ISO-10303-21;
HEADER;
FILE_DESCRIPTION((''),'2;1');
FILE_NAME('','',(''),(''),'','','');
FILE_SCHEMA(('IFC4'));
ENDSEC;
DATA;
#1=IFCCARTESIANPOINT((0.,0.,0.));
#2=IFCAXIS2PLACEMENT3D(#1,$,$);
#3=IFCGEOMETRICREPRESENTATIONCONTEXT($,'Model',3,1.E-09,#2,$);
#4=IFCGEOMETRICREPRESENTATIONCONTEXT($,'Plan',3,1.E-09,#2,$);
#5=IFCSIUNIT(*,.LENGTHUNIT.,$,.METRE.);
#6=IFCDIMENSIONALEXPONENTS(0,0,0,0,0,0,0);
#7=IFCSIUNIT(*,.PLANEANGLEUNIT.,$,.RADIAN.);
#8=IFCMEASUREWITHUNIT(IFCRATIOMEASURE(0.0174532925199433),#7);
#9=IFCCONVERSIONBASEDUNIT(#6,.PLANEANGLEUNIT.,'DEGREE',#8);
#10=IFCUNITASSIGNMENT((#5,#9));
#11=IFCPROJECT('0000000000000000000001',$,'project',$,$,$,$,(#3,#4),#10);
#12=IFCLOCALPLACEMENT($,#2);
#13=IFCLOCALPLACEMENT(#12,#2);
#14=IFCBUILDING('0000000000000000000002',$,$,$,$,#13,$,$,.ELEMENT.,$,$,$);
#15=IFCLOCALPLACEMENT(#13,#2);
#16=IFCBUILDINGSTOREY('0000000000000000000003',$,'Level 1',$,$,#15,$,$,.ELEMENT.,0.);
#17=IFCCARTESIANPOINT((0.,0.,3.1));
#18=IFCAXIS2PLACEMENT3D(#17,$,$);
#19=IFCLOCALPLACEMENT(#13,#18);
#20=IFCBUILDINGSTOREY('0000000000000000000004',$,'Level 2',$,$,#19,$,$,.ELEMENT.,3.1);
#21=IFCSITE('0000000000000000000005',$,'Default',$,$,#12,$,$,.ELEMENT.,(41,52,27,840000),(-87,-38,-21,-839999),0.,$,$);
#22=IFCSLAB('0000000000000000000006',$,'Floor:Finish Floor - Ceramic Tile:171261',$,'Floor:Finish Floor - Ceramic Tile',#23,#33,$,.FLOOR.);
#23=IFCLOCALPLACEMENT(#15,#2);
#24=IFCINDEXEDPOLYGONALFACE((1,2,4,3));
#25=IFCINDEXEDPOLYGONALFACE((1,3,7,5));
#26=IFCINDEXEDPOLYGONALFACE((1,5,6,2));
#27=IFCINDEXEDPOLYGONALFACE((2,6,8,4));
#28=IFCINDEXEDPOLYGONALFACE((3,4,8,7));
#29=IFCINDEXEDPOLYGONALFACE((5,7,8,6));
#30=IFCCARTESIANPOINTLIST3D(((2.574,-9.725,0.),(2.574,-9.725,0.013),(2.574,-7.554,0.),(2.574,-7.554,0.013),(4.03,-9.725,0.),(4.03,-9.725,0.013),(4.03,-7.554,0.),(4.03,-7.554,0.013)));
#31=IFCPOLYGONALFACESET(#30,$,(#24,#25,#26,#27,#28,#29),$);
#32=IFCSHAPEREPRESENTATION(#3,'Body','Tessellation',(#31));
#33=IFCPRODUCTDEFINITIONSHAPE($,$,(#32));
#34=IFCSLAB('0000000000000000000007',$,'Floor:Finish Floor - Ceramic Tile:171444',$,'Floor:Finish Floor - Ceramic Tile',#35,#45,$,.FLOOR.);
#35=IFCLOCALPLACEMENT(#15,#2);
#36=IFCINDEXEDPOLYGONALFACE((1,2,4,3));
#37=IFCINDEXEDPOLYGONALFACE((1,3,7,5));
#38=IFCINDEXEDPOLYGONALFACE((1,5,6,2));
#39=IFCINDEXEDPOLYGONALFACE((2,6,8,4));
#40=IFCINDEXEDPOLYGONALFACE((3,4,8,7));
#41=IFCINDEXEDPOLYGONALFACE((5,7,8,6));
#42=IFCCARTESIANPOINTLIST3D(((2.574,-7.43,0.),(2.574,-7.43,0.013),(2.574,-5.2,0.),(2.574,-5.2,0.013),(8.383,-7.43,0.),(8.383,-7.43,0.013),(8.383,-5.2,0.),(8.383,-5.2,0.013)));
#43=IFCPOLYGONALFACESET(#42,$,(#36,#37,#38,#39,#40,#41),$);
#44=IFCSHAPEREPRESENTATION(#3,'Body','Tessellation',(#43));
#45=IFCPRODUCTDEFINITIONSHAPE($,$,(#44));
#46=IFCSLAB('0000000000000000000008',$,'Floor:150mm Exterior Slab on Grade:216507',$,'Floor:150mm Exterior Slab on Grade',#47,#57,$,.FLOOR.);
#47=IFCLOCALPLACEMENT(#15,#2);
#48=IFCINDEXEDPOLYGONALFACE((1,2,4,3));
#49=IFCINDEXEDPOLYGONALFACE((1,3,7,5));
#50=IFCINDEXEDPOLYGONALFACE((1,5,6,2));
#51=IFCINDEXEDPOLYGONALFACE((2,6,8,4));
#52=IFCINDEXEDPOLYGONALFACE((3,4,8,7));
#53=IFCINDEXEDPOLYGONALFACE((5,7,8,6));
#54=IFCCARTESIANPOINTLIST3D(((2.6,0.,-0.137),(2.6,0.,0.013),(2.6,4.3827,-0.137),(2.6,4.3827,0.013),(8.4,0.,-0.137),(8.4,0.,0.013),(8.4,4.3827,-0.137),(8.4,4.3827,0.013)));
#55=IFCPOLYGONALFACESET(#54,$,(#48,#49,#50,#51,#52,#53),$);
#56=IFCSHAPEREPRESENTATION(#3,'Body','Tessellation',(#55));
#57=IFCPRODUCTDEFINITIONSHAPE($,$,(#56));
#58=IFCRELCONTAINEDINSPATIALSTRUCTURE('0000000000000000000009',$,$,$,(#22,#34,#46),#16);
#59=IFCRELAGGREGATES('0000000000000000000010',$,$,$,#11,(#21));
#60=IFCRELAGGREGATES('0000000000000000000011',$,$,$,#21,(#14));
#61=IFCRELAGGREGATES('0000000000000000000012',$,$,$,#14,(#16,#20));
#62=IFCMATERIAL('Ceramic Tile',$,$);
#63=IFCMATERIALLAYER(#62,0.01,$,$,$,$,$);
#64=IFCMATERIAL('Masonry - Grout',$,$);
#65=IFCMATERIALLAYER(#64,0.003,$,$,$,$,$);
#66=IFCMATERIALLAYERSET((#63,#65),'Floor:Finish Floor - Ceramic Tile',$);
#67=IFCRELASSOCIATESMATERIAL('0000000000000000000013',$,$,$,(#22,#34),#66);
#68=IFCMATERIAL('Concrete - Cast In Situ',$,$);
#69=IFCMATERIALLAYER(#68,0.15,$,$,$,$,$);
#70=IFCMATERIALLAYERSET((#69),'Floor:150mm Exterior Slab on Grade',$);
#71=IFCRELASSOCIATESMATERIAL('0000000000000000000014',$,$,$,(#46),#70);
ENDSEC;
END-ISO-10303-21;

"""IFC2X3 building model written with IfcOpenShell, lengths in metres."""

from ifc_helpers import new_model, entity, si_unit, converted_unit, frame, frame_2d, origin, place, context, project, spatial, rectangle, extrude, material, layer, layer_set, layer_usage, element, save


model = new_model("IFC2X3")

# Units and contexts
model_context = context("Model", 3, precision=1e-09, world=origin())
plan_context = context("Plan", 3, precision=1e-09, world=origin())
ifc_project = project(units=[si_unit("LENGTHUNIT", "METRE"), converted_unit("PLANEANGLEUNIT", "DEGREE", entity("IfcRatioMeasure", 0.0174532925199433), si_unit("PLANEANGLEUNIT", "RADIAN"), dimensions=[0, 0, 0, 0, 0, 0, 0])], contexts=[model_context, plan_context])

# Site, building, storey
site_placement = place(None, origin())
site = spatial("IfcSite", under=ifc_project, at=site_placement, Name="Default", CompositionType="ELEMENT", RefLatitude=(41, 52, 27, 840000), RefLongitude=(-87, -38, -21, -839999), RefElevation=0.0)
building_placement = place(site_placement, origin())
building = spatial("IfcBuilding", under=site, at=building_placement, CompositionType="ELEMENT")
storey_1_placement = place(building_placement, origin())
storey_1 = spatial("IfcBuildingStorey", under=building, at=storey_1_placement, Name="Level 1", CompositionType="ELEMENT", Elevation=0.0)

# Slabs
ifc_material_1 = material(Name="Ceramic Tile")
ifc_layer_1 = layer(ifc_material_1, 0.01)
ifc_material_2 = material(Name="Masonry - Grout")
ifc_layer_2 = layer(ifc_material_2, 0.003)
ifc_layer_set_1 = layer_set([ifc_layer_1, ifc_layer_2], Name="Floor:Finish Floor - Ceramic Tile")
ifc_layer_usage_1 = layer_usage(ifc_layer_set_1, "AXIS3", "POSITIVE", 0.0)
slab_1_placement = place(storey_1_placement, frame((2.574, -9.725, 0.0)))
element("IfcSlab", 1, at=slab_1_placement, inside=storey_1, material=ifc_layer_usage_1, Name="Floor:Finish Floor - Ceramic Tile:171261", ObjectType="Floor:Finish Floor - Ceramic Tile", PredefinedType="FLOOR", context=model_context, shape_type="SweptSolid", body=[
    extrude(rectangle(XDim=2.171, YDim=1.456, at=frame_2d((0.0, 0.0), x_axis=(0.0, -1.0))), frame((0.728, 1.0855, 0.013), z_axis=(0.0, 0.0, -1.0), x_axis=(-1.0, 0.0, 0.0)), (0.0, 0.0, 1.0), 0.013),
])
ifc_layer_usage_2 = layer_usage(ifc_layer_set_1, "AXIS3", "POSITIVE", 0.0)
slab_2_placement = place(storey_1_placement, frame((2.574, -7.43, 0.0)))
element("IfcSlab", 2, at=slab_2_placement, inside=storey_1, material=ifc_layer_usage_2, Name="Floor:Finish Floor - Ceramic Tile:171444", ObjectType="Floor:Finish Floor - Ceramic Tile", PredefinedType="FLOOR", context=model_context, shape_type="SweptSolid", body=[
    extrude(rectangle(XDim=5.809, YDim=2.23, at=frame_2d((0.0, 0.0), x_axis=(-1.0, 0.0))), frame((2.9045, 1.115, 0.013), z_axis=(0.0, 0.0, -1.0), x_axis=(-1.0, 0.0, 0.0)), (0.0, 0.0, 1.0), 0.013),
])
ifc_material_3 = material(Name="Concrete - Cast In Situ")
ifc_layer_3 = layer(ifc_material_3, 0.15)
ifc_layer_set_2 = layer_set([ifc_layer_3], Name="Floor:150mm Exterior Slab on Grade")
ifc_layer_usage_3 = layer_usage(ifc_layer_set_2, "AXIS3", "POSITIVE", 0.0)
slab_3_placement = place(storey_1_placement, frame((2.6, 0.0, -0.137)))
element("IfcSlab", 3, at=slab_3_placement, inside=storey_1, material=ifc_layer_usage_3, Name="Floor:150mm Exterior Slab on Grade:216507", ObjectType="Floor:150mm Exterior Slab on Grade", PredefinedType="FLOOR", context=model_context, shape_type="SweptSolid", body=[
    extrude(rectangle(XDim=5.8, YDim=4.3827, at=frame_2d((0.0, 0.0), x_axis=(-1.0, 0.0))), frame((2.9, 2.1914, 0.15), z_axis=(0.0, 0.0, -1.0), x_axis=(-1.0, 0.0, 0.0)), (0.0, 0.0, 1.0), 0.15),
])

# Shared definitions
storey_2_placement = place(building_placement, frame((0.0, 0.0, 3.1)))
storey_2 = spatial("IfcBuildingStorey", under=building, at=storey_2_placement, Name="Level 2", CompositionType="ELEMENT", Elevation=3.1)

save(model, "model.ifc")
